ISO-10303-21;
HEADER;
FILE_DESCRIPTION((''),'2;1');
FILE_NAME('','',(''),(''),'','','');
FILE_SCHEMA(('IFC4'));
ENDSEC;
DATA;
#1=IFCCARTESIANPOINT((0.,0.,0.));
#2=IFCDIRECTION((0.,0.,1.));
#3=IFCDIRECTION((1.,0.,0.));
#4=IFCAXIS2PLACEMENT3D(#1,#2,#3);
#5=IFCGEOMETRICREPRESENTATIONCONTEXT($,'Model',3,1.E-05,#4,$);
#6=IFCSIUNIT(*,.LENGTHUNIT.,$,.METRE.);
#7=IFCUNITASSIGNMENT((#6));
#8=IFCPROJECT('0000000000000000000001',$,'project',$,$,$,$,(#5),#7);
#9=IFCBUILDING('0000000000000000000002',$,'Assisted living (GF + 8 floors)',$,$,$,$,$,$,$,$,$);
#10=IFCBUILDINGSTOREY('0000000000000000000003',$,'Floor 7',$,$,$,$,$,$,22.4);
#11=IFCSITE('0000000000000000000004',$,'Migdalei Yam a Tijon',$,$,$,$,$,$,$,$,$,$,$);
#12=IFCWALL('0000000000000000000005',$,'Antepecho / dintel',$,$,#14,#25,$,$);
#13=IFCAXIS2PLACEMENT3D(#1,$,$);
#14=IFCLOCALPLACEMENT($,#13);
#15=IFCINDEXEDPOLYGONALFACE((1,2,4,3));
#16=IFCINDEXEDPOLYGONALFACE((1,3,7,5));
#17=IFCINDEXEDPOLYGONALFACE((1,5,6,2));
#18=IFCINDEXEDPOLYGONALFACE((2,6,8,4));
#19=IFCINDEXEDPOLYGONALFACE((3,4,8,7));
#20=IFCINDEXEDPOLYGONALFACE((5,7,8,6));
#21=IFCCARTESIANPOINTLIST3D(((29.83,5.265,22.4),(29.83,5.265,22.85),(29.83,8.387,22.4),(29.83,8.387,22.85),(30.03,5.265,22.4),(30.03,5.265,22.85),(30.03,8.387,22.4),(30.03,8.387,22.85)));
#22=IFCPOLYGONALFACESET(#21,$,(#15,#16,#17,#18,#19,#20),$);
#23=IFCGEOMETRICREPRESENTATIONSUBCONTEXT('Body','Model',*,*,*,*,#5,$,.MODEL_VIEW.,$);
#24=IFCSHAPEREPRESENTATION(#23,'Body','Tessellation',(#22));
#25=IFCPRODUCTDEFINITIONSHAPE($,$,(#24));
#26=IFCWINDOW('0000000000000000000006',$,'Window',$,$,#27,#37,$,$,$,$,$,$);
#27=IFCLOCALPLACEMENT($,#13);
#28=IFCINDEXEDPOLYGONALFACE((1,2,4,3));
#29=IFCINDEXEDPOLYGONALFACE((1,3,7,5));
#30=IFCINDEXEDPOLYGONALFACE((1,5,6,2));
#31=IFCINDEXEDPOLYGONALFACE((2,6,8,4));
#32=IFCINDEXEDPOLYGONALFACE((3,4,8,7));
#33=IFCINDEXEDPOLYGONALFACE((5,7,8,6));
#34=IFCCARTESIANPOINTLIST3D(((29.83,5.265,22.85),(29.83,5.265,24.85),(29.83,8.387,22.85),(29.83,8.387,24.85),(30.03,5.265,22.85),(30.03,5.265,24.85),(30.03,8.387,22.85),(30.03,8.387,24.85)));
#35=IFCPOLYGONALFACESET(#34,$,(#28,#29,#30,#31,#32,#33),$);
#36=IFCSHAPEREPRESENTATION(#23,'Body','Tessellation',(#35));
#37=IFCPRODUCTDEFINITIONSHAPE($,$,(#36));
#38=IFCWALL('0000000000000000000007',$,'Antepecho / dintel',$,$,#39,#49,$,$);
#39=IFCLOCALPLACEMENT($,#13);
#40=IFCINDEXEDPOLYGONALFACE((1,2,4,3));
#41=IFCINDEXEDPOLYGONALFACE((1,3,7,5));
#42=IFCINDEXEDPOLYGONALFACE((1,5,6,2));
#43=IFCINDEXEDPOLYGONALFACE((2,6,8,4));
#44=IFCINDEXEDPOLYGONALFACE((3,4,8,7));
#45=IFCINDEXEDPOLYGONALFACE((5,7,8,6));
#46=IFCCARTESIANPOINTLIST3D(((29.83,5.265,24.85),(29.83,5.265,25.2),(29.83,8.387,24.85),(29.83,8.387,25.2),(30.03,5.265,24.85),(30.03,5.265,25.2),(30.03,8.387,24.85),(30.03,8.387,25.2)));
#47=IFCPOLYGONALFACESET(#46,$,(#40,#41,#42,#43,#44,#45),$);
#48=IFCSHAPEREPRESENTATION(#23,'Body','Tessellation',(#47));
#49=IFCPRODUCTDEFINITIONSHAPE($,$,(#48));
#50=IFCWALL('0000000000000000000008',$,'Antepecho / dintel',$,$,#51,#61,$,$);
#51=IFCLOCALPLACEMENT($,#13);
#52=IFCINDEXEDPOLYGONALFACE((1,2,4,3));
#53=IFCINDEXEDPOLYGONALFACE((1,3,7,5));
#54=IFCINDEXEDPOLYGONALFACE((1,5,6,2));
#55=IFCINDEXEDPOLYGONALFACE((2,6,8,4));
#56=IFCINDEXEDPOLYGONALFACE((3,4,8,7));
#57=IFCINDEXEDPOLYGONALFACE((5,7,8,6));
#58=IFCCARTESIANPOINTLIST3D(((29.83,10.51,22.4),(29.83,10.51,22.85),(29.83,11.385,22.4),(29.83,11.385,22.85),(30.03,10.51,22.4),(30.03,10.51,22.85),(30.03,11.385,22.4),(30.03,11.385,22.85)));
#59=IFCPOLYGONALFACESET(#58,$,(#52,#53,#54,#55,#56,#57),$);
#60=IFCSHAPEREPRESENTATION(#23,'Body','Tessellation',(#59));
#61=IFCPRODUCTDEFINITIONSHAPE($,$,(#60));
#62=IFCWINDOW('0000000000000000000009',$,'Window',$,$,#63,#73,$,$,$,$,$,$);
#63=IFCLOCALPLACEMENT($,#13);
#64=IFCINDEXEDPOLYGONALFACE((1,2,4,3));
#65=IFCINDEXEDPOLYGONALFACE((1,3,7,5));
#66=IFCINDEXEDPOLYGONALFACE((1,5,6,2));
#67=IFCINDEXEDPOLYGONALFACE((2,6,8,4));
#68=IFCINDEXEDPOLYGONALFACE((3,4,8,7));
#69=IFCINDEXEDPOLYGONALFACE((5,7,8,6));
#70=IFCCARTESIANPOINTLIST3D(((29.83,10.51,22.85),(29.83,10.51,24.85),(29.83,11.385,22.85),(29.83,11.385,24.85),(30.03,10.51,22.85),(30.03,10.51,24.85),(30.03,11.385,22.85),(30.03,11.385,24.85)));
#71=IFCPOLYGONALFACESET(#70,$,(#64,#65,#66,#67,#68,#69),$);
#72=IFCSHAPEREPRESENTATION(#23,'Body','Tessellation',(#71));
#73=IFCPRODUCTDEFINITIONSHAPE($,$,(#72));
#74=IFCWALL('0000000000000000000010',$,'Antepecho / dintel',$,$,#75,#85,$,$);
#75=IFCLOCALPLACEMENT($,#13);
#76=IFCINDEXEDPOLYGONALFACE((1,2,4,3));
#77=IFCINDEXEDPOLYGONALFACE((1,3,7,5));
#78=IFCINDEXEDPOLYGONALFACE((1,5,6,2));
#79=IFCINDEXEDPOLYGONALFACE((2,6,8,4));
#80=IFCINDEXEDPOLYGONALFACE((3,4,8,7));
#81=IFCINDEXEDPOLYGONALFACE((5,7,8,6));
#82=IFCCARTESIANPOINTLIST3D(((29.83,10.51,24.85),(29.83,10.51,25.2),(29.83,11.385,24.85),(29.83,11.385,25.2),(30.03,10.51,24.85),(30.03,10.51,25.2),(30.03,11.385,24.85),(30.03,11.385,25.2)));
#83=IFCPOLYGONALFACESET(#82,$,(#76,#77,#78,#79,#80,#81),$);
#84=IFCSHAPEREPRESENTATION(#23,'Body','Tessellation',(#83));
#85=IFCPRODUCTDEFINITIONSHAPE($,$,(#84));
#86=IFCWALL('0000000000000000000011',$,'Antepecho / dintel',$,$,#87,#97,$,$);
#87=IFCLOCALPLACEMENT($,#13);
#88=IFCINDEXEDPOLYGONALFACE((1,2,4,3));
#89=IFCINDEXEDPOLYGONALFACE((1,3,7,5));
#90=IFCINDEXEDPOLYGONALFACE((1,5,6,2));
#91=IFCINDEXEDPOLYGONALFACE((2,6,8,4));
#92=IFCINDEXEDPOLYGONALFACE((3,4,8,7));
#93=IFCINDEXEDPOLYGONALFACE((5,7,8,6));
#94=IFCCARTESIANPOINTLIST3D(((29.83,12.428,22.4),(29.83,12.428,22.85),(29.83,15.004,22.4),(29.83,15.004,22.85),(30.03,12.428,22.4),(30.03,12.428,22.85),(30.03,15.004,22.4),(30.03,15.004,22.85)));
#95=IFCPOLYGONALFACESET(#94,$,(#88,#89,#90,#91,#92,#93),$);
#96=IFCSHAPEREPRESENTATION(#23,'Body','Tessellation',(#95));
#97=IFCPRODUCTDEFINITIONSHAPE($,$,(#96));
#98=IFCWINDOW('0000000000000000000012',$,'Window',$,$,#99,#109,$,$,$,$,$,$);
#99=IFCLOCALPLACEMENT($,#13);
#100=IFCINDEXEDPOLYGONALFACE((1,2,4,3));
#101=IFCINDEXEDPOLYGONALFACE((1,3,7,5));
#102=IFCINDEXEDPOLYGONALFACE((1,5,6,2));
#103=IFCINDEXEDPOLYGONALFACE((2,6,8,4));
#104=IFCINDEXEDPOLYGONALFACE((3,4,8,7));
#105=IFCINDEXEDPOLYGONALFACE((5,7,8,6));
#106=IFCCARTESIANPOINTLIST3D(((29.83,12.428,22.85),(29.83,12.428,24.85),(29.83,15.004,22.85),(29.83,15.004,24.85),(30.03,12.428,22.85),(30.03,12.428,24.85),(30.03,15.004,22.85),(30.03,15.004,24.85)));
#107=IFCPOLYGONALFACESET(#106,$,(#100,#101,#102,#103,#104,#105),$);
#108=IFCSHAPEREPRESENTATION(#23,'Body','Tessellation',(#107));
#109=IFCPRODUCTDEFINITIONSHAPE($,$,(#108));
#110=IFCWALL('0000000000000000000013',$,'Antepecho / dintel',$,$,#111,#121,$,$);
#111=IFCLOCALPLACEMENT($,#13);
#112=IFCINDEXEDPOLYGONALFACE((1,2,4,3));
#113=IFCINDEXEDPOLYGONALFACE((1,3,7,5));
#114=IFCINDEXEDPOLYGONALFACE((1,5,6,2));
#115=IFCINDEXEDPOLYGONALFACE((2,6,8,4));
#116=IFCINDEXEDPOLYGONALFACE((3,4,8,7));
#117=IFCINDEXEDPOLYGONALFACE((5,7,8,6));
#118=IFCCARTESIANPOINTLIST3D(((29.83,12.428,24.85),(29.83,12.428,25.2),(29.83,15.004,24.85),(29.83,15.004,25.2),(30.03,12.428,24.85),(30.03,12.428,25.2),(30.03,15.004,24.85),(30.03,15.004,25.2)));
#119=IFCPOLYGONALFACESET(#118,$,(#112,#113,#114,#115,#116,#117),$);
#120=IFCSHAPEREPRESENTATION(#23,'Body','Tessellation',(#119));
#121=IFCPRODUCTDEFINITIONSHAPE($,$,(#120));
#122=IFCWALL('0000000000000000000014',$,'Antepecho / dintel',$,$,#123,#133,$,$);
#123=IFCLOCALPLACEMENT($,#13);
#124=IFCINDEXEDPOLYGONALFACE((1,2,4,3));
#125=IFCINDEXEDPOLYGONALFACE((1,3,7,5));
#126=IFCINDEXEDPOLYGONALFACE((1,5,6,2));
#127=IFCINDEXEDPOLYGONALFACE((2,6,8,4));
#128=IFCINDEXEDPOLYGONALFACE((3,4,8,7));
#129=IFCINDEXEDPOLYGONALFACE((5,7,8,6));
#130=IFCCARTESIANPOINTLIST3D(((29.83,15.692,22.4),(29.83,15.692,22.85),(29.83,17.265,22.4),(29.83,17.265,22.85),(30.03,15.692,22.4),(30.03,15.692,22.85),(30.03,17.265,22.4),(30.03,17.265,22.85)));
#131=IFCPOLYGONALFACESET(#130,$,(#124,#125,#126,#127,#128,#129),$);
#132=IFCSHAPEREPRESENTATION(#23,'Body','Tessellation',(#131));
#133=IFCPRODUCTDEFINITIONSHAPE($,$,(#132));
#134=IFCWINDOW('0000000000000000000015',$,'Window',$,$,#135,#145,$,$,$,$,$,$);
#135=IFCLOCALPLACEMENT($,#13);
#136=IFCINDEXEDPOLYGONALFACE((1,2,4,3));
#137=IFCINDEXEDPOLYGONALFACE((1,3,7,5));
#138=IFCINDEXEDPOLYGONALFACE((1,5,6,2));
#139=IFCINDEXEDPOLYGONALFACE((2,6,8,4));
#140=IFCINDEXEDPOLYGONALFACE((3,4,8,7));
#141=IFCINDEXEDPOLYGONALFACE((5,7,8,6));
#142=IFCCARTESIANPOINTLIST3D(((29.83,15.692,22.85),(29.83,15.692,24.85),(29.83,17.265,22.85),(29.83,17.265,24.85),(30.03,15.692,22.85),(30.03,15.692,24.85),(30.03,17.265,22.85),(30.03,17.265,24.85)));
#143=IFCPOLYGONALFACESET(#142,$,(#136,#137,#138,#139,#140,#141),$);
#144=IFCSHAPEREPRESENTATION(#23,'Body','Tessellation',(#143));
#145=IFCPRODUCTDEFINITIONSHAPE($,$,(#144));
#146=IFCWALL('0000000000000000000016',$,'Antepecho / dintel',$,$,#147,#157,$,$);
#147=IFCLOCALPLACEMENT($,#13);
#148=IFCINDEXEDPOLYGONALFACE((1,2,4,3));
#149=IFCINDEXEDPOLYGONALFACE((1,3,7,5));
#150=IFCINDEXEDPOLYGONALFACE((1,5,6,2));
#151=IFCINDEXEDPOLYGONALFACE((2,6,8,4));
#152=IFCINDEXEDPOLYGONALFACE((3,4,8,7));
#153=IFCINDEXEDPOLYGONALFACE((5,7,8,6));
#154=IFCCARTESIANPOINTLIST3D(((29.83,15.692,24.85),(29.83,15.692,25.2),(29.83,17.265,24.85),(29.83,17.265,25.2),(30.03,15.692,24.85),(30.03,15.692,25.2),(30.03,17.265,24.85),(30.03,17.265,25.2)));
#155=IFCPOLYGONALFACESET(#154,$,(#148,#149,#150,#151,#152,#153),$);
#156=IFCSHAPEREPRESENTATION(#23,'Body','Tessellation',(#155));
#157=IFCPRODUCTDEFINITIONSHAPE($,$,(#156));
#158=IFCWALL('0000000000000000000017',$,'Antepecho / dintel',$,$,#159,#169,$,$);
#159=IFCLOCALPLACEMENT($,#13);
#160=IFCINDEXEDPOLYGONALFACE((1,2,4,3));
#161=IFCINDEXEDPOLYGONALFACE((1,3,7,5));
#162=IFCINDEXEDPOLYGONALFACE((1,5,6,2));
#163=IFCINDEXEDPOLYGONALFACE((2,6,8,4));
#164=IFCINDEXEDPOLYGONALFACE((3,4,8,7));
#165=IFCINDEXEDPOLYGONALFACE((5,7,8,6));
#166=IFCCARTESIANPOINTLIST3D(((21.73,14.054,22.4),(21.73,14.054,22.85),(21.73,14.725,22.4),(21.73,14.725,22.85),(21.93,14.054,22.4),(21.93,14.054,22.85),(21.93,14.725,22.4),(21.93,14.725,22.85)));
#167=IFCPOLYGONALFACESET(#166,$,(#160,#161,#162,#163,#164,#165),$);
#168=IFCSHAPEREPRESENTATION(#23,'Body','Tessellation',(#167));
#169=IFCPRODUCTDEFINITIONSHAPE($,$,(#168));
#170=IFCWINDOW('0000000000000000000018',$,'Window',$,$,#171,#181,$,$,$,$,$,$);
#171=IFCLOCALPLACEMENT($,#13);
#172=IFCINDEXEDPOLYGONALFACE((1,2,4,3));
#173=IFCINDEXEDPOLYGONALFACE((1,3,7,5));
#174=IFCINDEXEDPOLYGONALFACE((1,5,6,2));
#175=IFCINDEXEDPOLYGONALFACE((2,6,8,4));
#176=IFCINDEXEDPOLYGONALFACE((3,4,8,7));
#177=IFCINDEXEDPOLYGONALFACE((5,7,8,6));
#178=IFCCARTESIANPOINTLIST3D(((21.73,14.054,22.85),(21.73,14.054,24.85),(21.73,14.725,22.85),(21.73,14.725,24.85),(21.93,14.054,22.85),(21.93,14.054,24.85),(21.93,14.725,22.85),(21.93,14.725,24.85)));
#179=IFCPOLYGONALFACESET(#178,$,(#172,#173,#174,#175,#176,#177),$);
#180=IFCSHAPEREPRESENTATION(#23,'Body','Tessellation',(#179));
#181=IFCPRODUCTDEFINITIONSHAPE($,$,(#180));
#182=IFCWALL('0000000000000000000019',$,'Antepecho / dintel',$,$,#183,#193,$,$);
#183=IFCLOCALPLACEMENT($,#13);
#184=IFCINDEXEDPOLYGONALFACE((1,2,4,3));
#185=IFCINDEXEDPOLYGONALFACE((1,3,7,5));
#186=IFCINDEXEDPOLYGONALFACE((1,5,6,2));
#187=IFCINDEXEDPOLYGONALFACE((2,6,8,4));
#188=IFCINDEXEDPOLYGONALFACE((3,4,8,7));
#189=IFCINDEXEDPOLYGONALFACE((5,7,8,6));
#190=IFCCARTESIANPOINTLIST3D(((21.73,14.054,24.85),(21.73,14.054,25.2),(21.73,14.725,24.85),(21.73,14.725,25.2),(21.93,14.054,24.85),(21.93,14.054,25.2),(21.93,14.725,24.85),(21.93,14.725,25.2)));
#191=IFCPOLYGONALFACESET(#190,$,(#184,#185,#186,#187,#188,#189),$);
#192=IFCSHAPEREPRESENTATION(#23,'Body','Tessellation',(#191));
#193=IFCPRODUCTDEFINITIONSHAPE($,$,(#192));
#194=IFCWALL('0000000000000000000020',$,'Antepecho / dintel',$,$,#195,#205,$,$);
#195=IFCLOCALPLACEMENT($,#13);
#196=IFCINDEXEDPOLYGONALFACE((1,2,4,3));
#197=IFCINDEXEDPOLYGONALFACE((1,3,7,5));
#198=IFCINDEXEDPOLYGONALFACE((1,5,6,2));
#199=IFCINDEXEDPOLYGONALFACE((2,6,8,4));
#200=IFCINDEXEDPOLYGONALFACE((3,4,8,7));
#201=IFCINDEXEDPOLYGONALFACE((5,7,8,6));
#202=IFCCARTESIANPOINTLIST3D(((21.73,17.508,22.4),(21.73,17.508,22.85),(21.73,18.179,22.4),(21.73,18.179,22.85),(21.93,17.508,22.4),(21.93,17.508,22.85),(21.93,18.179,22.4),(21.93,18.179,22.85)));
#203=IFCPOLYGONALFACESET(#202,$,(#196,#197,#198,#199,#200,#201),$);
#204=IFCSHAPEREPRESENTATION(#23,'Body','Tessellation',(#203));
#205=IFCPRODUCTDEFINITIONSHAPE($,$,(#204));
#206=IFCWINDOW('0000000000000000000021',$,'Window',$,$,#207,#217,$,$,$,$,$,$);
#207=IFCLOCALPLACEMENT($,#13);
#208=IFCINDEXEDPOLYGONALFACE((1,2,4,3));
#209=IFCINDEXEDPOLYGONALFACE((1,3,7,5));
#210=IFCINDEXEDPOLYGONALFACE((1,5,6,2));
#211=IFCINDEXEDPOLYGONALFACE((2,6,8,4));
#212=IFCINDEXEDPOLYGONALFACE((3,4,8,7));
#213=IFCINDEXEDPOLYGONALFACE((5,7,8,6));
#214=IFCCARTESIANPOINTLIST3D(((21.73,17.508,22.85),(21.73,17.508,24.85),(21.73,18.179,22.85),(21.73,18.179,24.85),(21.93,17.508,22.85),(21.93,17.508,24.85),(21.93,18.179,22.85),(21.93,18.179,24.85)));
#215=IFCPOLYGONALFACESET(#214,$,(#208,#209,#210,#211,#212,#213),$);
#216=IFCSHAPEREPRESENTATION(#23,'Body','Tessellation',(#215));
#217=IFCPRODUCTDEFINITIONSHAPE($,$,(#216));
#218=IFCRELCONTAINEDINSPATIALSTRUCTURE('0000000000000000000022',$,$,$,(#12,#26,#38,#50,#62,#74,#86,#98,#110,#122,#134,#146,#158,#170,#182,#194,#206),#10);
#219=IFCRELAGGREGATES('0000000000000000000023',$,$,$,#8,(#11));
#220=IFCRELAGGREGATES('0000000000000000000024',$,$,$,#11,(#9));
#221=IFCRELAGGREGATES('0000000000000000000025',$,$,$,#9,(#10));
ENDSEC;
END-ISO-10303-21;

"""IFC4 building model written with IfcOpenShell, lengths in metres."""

from ifc_helpers import new_model, si_unit, frame, origin_with_axes, context, subcontext, project, spatial, line, indexed_curve, outline, extrude, element, save


model = new_model("IFC4")

# Units and contexts
model_context = context("Model", 3, precision=1e-05, world=origin_with_axes())
body_context = subcontext(model_context, "Body", "Model", "MODEL_VIEW")
ifc_project = project(units=[si_unit("LENGTHUNIT", "METRE")], contexts=[model_context])

# Site, building, storey
site = spatial("IfcSite", under=ifc_project, Name="Migdalei Yam a Tijon")
building = spatial("IfcBuilding", under=site, Name="Assisted living (GF + 8 floors)")
storey = spatial("IfcBuildingStorey", under=building, Name="Floor 7", Elevation=22.4)

# Wall
element("IfcWall", 1, inside=storey, Name="Antepecho / dintel", context=body_context, shape_type="SweptSolid", body=[
    extrude(outline(indexed_curve([(0.0, 0.0), (0.2, 0.0), (0.2, 3.122), (0.0, 3.122)], segments=[line(1, 2, 3, 4, 1)])), frame((29.83, 5.265, 22.4), z_axis=(0.0, 0.0, 1.0), x_axis=(1.0, 0.0, 0.0)), (0.0, 0.0, 1.0), 0.45),
])

# Window
element("IfcWindow", 2, inside=storey, Name="Window", context=body_context, shape_type="SweptSolid", body=[
    extrude(outline(indexed_curve([(0.0, 0.0), (0.2, 0.0), (0.2, 3.122), (0.0, 3.122)], segments=[line(1, 2, 3, 4, 1)])), frame((29.83, 5.265, 22.85), z_axis=(0.0, 0.0, 1.0), x_axis=(1.0, 0.0, 0.0)), (0.0, 0.0, 1.0), 2.0),
])

# Walls
element("IfcWall", 3, inside=storey, Name="Antepecho / dintel", context=body_context, shape_type="SweptSolid", body=[
    extrude(outline(indexed_curve([(0.0, 0.0), (0.2, 0.0), (0.2, 3.122), (0.0, 3.122)], segments=[line(1, 2, 3, 4, 1)])), frame((29.83, 5.265, 24.85), z_axis=(0.0, 0.0, 1.0), x_axis=(1.0, 0.0, 0.0)), (0.0, 0.0, 1.0), 0.35),
])
element("IfcWall", 4, inside=storey, Name="Antepecho / dintel", context=body_context, shape_type="SweptSolid", body=[
    extrude(outline(indexed_curve([(0.0, 0.0), (0.2, 0.0), (0.2, 0.875), (0.0, 0.875)], segments=[line(1, 2, 3, 4, 1)])), frame((29.83, 10.51, 22.4), z_axis=(0.0, 0.0, 1.0), x_axis=(1.0, 0.0, 0.0)), (0.0, 0.0, 1.0), 0.45),
])

# Window
element("IfcWindow", 5, inside=storey, Name="Window", context=body_context, shape_type="SweptSolid", body=[
    extrude(outline(indexed_curve([(0.0, 0.0), (0.2, 0.0), (0.2, 0.875), (0.0, 0.875)], segments=[line(1, 2, 3, 4, 1)])), frame((29.83, 10.51, 22.85), z_axis=(0.0, 0.0, 1.0), x_axis=(1.0, 0.0, 0.0)), (0.0, 0.0, 1.0), 2.0),
])

# Walls
element("IfcWall", 6, inside=storey, Name="Antepecho / dintel", context=body_context, shape_type="SweptSolid", body=[
    extrude(outline(indexed_curve([(0.0, 0.0), (0.2, 0.0), (0.2, 0.875), (0.0, 0.875)], segments=[line(1, 2, 3, 4, 1)])), frame((29.83, 10.51, 24.85), z_axis=(0.0, 0.0, 1.0), x_axis=(1.0, 0.0, 0.0)), (0.0, 0.0, 1.0), 0.35),
])
element("IfcWall", 7, inside=storey, Name="Antepecho / dintel", context=body_context, shape_type="SweptSolid", body=[
    extrude(outline(indexed_curve([(0.0, 0.0), (0.2, 0.0), (0.2, 2.576), (0.0, 2.576)], segments=[line(1, 2, 3, 4, 1)])), frame((29.83, 12.428, 22.4), z_axis=(0.0, 0.0, 1.0), x_axis=(1.0, 0.0, 0.0)), (0.0, 0.0, 1.0), 0.45),
])

# Window
element("IfcWindow", 8, inside=storey, Name="Window", context=body_context, shape_type="SweptSolid", body=[
    extrude(outline(indexed_curve([(0.0, 0.0), (0.2, 0.0), (0.2, 2.576), (0.0, 2.576)], segments=[line(1, 2, 3, 4, 1)])), frame((29.83, 12.428, 22.85), z_axis=(0.0, 0.0, 1.0), x_axis=(1.0, 0.0, 0.0)), (0.0, 0.0, 1.0), 2.0),
])

# Walls
element("IfcWall", 9, inside=storey, Name="Antepecho / dintel", context=body_context, shape_type="SweptSolid", body=[
    extrude(outline(indexed_curve([(0.0, 0.0), (0.2, 0.0), (0.2, 2.576), (0.0, 2.576)], segments=[line(1, 2, 3, 4, 1)])), frame((29.83, 12.428, 24.85), z_axis=(0.0, 0.0, 1.0), x_axis=(1.0, 0.0, 0.0)), (0.0, 0.0, 1.0), 0.35),
])
element("IfcWall", 10, inside=storey, Name="Antepecho / dintel", context=body_context, shape_type="SweptSolid", body=[
    extrude(outline(indexed_curve([(0.0, 0.0), (0.2, 0.0), (0.2, 1.573), (0.0, 1.573)], segments=[line(1, 2, 3, 4, 1)])), frame((29.83, 15.692, 22.4), z_axis=(0.0, 0.0, 1.0), x_axis=(1.0, 0.0, 0.0)), (0.0, 0.0, 1.0), 0.45),
])

# Window
element("IfcWindow", 11, inside=storey, Name="Window", context=body_context, shape_type="SweptSolid", body=[
    extrude(outline(indexed_curve([(0.0, 0.0), (0.2, 0.0), (0.2, 1.573), (0.0, 1.573)], segments=[line(1, 2, 3, 4, 1)])), frame((29.83, 15.692, 22.85), z_axis=(0.0, 0.0, 1.0), x_axis=(1.0, 0.0, 0.0)), (0.0, 0.0, 1.0), 2.0),
])

# Walls
element("IfcWall", 12, inside=storey, Name="Antepecho / dintel", context=body_context, shape_type="SweptSolid", body=[
    extrude(outline(indexed_curve([(0.0, 0.0), (0.2, 0.0), (0.2, 1.573), (0.0, 1.573)], segments=[line(1, 2, 3, 4, 1)])), frame((29.83, 15.692, 24.85), z_axis=(0.0, 0.0, 1.0), x_axis=(1.0, 0.0, 0.0)), (0.0, 0.0, 1.0), 0.35),
])
element("IfcWall", 13, inside=storey, Name="Antepecho / dintel", context=body_context, shape_type="SweptSolid", body=[
    extrude(outline(indexed_curve([(0.0, 0.0), (0.2, 0.0), (0.2, 0.671), (0.0, 0.671)], segments=[line(1, 2, 3, 4, 1)])), frame((21.73, 14.054, 22.4), z_axis=(0.0, 0.0, 1.0), x_axis=(1.0, 0.0, 0.0)), (0.0, 0.0, 1.0), 0.45),
])

# Window
element("IfcWindow", 14, inside=storey, Name="Window", context=body_context, shape_type="SweptSolid", body=[
    extrude(outline(indexed_curve([(0.0, 0.0), (0.2, 0.0), (0.2, 0.671), (0.0, 0.671)], segments=[line(1, 2, 3, 4, 1)])), frame((21.73, 14.054, 22.85), z_axis=(0.0, 0.0, 1.0), x_axis=(1.0, 0.0, 0.0)), (0.0, 0.0, 1.0), 2.0),
])

# Walls
element("IfcWall", 15, inside=storey, Name="Antepecho / dintel", context=body_context, shape_type="SweptSolid", body=[
    extrude(outline(indexed_curve([(0.0, 0.0), (0.2, 0.0), (0.2, 0.671), (0.0, 0.671)], segments=[line(1, 2, 3, 4, 1)])), frame((21.73, 14.054, 24.85), z_axis=(0.0, 0.0, 1.0), x_axis=(1.0, 0.0, 0.0)), (0.0, 0.0, 1.0), 0.35),
])
element("IfcWall", 16, inside=storey, Name="Antepecho / dintel", context=body_context, shape_type="SweptSolid", body=[
    extrude(outline(indexed_curve([(0.0, 0.0), (0.2, 0.0), (0.2, 0.671), (0.0, 0.671)], segments=[line(1, 2, 3, 4, 1)])), frame((21.73, 17.508, 22.4), z_axis=(0.0, 0.0, 1.0), x_axis=(1.0, 0.0, 0.0)), (0.0, 0.0, 1.0), 0.45),
])

# Window
element("IfcWindow", 17, inside=storey, Name="Window", context=body_context, shape_type="SweptSolid", body=[
    extrude(outline(indexed_curve([(0.0, 0.0), (0.2, 0.0), (0.2, 0.671), (0.0, 0.671)], segments=[line(1, 2, 3, 4, 1)])), frame((21.73, 17.508, 22.85), z_axis=(0.0, 0.0, 1.0), x_axis=(1.0, 0.0, 0.0)), (0.0, 0.0, 1.0), 2.0),
])

save(model, "model.ifc")
